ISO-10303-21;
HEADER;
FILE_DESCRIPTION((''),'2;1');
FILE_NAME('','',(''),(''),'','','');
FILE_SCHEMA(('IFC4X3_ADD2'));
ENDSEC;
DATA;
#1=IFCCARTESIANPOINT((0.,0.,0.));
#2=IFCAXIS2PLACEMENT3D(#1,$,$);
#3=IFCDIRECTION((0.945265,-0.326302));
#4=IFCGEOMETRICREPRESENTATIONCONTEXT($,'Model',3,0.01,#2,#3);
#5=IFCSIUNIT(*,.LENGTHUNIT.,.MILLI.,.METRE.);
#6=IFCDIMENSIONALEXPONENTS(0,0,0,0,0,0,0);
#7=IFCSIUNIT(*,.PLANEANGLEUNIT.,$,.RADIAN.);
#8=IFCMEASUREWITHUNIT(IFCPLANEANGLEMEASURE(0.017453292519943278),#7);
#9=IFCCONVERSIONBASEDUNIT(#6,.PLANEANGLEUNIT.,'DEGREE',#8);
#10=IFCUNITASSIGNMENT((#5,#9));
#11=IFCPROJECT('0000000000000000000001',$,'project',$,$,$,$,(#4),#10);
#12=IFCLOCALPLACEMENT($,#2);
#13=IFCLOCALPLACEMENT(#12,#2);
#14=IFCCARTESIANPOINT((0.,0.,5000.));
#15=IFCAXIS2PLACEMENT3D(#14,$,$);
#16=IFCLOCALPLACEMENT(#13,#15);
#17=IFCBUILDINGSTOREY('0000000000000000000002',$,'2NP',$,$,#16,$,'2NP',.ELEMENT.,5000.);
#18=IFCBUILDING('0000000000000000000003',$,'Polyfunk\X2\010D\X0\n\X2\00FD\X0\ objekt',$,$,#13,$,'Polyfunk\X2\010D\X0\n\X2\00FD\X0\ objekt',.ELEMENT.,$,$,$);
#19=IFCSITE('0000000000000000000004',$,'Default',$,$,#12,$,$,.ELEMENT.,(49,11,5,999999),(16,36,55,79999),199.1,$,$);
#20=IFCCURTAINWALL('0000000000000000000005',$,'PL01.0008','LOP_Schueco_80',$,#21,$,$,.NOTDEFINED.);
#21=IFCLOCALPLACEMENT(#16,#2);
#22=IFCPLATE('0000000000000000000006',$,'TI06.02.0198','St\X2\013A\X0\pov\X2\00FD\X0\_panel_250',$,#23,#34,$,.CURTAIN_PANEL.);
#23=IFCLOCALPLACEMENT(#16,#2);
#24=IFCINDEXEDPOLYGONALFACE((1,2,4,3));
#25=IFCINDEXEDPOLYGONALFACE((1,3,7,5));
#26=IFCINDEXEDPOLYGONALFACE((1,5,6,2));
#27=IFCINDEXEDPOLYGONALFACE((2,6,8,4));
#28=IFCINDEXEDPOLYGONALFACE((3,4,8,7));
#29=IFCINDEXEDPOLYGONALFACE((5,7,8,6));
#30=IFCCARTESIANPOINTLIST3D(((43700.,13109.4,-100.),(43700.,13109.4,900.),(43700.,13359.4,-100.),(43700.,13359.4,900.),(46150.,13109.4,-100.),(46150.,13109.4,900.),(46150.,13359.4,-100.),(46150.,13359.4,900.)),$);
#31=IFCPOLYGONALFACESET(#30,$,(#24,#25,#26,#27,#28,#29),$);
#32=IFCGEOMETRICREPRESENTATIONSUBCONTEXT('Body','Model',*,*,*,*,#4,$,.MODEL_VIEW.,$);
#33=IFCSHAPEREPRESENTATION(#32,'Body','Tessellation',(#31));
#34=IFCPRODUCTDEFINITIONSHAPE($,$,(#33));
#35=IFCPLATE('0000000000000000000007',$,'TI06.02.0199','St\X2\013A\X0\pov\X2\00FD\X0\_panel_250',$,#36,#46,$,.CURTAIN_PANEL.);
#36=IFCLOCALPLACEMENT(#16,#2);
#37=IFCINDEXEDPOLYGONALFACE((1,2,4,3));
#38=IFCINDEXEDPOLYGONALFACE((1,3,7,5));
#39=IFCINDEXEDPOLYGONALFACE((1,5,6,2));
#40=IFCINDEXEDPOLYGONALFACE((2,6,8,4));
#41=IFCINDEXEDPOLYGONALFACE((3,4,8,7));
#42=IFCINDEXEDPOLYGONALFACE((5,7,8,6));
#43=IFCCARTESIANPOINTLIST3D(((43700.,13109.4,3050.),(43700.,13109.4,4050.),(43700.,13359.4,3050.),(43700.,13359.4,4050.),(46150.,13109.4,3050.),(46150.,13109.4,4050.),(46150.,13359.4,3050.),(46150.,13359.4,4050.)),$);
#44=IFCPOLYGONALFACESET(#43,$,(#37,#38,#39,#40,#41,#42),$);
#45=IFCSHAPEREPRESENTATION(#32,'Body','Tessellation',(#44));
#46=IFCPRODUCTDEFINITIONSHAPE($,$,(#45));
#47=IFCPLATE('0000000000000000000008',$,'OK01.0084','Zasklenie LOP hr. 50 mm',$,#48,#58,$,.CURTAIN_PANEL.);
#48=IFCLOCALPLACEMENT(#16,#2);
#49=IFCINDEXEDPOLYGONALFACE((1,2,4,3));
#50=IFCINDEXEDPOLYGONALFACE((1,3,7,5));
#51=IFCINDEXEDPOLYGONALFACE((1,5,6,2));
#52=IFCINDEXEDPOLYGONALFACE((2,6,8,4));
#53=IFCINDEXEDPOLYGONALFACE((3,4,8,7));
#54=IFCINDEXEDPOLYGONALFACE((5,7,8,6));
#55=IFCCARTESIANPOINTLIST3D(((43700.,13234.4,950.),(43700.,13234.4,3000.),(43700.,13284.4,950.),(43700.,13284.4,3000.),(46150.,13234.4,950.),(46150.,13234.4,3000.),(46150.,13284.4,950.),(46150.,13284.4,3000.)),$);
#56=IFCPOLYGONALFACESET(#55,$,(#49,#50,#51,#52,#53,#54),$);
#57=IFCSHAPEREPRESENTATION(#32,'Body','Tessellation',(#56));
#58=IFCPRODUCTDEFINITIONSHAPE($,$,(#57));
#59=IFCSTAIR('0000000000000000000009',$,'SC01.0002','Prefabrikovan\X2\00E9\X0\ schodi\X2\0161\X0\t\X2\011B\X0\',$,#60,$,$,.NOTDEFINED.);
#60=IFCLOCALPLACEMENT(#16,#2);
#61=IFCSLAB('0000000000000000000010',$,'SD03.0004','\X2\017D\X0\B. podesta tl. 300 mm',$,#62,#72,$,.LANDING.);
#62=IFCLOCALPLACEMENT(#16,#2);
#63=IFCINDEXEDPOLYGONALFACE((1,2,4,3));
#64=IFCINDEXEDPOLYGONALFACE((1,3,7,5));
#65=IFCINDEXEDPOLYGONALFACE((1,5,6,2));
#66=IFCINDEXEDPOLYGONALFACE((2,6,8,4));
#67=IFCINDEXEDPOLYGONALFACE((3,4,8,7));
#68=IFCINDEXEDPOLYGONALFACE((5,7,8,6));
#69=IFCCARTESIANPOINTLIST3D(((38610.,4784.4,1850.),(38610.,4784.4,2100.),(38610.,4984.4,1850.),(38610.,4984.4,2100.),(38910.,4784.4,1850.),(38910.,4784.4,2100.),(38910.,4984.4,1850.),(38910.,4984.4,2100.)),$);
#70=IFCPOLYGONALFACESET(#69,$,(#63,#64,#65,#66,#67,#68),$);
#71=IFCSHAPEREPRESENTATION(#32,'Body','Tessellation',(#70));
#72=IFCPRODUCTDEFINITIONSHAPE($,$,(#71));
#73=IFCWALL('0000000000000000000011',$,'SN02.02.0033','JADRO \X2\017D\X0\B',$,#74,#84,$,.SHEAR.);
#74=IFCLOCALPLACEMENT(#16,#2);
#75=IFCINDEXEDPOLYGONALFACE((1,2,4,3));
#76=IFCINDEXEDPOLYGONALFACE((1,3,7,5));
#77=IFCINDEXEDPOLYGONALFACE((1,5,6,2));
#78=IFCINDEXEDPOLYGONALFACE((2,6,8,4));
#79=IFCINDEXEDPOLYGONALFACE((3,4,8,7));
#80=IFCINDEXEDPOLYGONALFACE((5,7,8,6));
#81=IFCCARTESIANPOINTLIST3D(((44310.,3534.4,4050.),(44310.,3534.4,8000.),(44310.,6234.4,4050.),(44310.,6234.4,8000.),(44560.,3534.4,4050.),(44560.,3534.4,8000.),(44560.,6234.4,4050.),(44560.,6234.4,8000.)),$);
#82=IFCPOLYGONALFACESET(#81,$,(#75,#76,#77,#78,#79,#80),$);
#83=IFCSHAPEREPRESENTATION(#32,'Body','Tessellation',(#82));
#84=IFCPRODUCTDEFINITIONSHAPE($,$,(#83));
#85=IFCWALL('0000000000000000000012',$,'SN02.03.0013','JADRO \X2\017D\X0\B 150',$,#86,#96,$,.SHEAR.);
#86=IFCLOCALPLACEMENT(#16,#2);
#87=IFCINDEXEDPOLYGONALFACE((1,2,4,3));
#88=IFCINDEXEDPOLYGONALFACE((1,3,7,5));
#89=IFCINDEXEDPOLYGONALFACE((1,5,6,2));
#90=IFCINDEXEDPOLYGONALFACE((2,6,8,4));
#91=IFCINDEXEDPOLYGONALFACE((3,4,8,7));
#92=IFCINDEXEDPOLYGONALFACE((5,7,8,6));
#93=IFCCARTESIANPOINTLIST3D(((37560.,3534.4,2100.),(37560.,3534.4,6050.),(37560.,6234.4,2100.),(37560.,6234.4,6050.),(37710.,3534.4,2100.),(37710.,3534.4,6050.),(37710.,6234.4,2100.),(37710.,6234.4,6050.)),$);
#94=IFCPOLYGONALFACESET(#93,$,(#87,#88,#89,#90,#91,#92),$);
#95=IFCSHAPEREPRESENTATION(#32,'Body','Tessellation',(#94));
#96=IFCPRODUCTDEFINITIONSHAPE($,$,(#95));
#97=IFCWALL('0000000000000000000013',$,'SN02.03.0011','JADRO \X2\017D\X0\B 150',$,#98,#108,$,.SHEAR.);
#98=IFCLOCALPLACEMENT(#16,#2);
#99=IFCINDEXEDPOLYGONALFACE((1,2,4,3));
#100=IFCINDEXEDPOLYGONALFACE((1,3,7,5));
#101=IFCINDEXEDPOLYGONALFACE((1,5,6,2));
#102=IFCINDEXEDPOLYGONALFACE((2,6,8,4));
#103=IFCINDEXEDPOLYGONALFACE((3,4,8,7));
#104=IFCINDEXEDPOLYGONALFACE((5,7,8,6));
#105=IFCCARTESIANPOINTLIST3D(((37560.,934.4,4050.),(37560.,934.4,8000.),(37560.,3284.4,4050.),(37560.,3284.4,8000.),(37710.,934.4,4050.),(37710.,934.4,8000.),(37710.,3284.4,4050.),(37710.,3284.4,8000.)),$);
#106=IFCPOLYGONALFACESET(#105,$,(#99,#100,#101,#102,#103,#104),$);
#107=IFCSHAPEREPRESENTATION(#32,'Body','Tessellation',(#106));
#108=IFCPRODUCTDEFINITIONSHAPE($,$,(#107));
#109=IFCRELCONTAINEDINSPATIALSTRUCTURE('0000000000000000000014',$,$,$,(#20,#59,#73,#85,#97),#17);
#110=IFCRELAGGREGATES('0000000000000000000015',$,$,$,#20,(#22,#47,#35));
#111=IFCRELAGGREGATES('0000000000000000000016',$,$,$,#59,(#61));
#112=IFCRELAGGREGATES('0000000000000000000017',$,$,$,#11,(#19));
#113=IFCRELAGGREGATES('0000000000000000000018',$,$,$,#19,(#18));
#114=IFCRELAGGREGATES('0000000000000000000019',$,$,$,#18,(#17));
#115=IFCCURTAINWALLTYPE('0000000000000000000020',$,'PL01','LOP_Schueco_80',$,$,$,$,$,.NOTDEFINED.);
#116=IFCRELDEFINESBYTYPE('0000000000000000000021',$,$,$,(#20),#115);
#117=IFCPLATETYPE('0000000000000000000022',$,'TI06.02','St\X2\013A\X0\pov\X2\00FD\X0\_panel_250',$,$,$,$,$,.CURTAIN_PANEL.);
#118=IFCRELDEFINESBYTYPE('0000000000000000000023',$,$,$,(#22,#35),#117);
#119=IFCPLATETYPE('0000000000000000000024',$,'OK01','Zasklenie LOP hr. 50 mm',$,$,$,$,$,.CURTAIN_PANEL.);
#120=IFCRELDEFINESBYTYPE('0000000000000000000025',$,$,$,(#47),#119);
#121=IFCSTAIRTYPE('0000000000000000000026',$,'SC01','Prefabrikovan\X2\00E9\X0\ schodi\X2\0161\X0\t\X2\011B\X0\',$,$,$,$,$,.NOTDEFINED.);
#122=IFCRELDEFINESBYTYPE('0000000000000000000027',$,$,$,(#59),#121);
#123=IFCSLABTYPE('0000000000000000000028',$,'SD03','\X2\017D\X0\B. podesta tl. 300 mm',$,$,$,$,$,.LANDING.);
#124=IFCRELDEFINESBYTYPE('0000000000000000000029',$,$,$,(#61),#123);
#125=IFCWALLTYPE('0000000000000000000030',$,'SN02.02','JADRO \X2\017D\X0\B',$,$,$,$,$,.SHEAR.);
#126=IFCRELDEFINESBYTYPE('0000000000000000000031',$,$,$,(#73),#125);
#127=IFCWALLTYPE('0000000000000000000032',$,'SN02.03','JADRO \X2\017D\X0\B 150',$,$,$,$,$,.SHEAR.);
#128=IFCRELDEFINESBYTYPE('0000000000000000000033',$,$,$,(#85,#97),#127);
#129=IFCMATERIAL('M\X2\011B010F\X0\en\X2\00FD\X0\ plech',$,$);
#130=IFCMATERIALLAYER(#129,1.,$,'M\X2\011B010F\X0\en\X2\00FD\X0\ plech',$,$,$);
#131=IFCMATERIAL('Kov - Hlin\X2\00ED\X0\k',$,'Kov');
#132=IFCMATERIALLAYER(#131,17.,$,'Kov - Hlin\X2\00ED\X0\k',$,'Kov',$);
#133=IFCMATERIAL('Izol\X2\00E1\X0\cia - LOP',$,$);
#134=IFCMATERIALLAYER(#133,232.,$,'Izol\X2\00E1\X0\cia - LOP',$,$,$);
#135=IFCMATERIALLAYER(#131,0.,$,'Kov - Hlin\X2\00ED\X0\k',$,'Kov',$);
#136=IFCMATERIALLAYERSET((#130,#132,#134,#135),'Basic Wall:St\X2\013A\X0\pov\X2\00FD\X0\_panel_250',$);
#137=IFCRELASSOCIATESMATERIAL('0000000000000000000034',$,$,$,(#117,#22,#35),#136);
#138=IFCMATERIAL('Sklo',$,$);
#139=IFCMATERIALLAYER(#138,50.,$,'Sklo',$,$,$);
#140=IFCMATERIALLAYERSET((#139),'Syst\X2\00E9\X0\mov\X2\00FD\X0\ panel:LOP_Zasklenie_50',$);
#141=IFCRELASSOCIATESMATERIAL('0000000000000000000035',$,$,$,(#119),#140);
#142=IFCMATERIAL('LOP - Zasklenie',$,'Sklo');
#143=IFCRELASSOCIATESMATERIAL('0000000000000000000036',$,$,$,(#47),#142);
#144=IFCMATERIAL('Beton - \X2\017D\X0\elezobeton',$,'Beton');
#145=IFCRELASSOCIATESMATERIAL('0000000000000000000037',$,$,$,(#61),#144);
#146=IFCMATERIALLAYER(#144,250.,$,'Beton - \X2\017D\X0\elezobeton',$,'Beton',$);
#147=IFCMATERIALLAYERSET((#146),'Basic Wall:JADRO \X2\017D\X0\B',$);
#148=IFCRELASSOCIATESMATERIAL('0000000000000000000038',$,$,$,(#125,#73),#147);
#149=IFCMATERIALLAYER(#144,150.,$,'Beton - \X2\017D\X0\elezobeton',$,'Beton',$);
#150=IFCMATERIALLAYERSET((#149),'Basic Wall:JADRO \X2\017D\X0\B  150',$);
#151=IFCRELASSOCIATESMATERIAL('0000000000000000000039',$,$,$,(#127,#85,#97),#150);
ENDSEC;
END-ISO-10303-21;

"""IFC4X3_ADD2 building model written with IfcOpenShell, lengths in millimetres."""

from ifc_helpers import new_model, entity, si_unit, converted_unit, direction, frame, frame_2d, origin, origin_2d_with_axis, place, context, subcontext, project, spatial, polyline, rectangle, extrude, clip, bounded_halfspace, source, transform, mapped, material, layer, layer_set, layer_usage, type_object, type_shapes, element, aggregate, save


model = new_model("IFC4X3_ADD2")

# Units and contexts
model_context = context("Model", 3, precision=0.01, world=origin(), true_north=direction((0.945265, -0.326302)))
body_context = subcontext(model_context, "Body", "Model", "MODEL_VIEW")
ifc_project = project(units=[si_unit("LENGTHUNIT", "METRE", prefix="MILLI"), converted_unit("PLANEANGLEUNIT", "DEGREE", entity("IfcPlaneAngleMeasure", 0.017453292519943278), si_unit("PLANEANGLEUNIT", "RADIAN"), dimensions=[0, 0, 0, 0, 0, 0, 0])], contexts=[model_context])

# Site, building, storey
site_placement = place(None, origin())
site = spatial("IfcSite", under=ifc_project, at=site_placement, Name="Default", CompositionType="ELEMENT", RefLatitude=(49, 11, 5, 999999), RefLongitude=(16, 36, 55, 79999), RefElevation=199.1)
building_placement = place(site_placement, origin())
building = spatial("IfcBuilding", under=site, at=building_placement, Name="Polyfunkčný objekt", LongName="Polyfunkčný objekt", CompositionType="ELEMENT")
storey_placement = place(building_placement, frame((0.0, 0.0, 5000.0)))
storey = spatial("IfcBuildingStorey", under=building, at=storey_placement, Name="2NP", LongName="2NP", CompositionType="ELEMENT", Elevation=5000.0)

# Curtain wall, plates
curtain_wall_type = type_object("IfcCurtainWallType", Name="PL01", Description="LOP_Schueco_80", PredefinedType="NOTDEFINED")
curtain_wall_placement = place(storey_placement, frame((0.0, 0.0, -5000.0)))
curtain_wall = element("IfcCurtainWall", 1, at=curtain_wall_placement, inside=storey, type_object=curtain_wall_type, Name="PL01.0008", Description="LOP_Schueco_80", PredefinedType="NOTDEFINED")
ifc_material_1 = material(Name="Měďený plech")
ifc_layer_1 = layer(ifc_material_1, 1.0, Name="Měďený plech")
ifc_material_2 = material(Name="Kov - Hliník", Category="Kov")
ifc_layer_2 = layer(ifc_material_2, 17.0, Name="Kov - Hliník", Category="Kov")
ifc_material_3 = material(Name="Izolácia - LOP")
ifc_layer_3 = layer(ifc_material_3, 232.0, Name="Izolácia - LOP")
ifc_layer_4 = layer(ifc_material_2, 0.0, Name="Kov - Hliník", Category="Kov")
ifc_layer_set_1 = layer_set([ifc_layer_1, ifc_layer_2, ifc_layer_3, ifc_layer_4], Name="Basic Wall:Stĺpový_panel_250")
ifc_layer_usage_1 = layer_usage(ifc_layer_set_1, "AXIS2", "NEGATIVE", 125.0)
plate_type_1 = type_object("IfcPlateType", Name="TI06.02", Description="Stĺpový_panel_250", PredefinedType="CURTAIN_PANEL", material=ifc_layer_set_1)
plate_1_placement = place(storey_placement, frame((43700.0, 13234.4, -100.0)))
plate_1 = element("IfcPlate", 2, at=plate_1_placement, type_object=plate_type_1, material=ifc_layer_usage_1, Name="TI06.02.0198", Description="Stĺpový_panel_250", PredefinedType="CURTAIN_PANEL", context=body_context, shape_type="SweptSolid", body=[
    extrude(rectangle(XDim=250.0, YDim=2450.0, at=frame_2d((0.0, 0.0), x_axis=(1.0, 0.0))), frame((1225.0, 0.0, 0.0), z_axis=(0.0, 0.0, 1.0), x_axis=(0.0, 1.0, 0.0)), (0.0, 0.0, 1.0), 1000.0),
])
ifc_layer_usage_2 = layer_usage(ifc_layer_set_1, "AXIS2", "NEGATIVE", 125.0)
plate_2_placement = place(storey_placement, frame((43700.0, 13234.4, 3050.0)))
plate_2 = element("IfcPlate", 3, at=plate_2_placement, type_object=plate_type_1, material=ifc_layer_usage_2, Name="TI06.02.0199", Description="Stĺpový_panel_250", PredefinedType="CURTAIN_PANEL", context=body_context, shape_type="SweptSolid", body=[
    extrude(rectangle(XDim=250.0, YDim=2450.0, at=frame_2d((0.0, 0.0), x_axis=(1.0, 0.0))), frame((1225.0, 0.0, 0.0), z_axis=(0.0, 0.0, 1.0), x_axis=(0.0, 1.0, 0.0)), (0.0, 0.0, 1.0), 1000.0),
])
ifc_material_4 = material(Name="LOP - Zasklenie", Category="Sklo")
ifc_material_5 = material(Name="Sklo")
ifc_layer_5 = layer(ifc_material_5, 50.0, Name="Sklo")
ifc_layer_set_2 = layer_set([ifc_layer_5], Name="Systémový panel:LOP_Zasklenie_50")
plate_type_2 = type_object("IfcPlateType", Name="OK01", Description="Zasklenie LOP hr. 50 mm", PredefinedType="CURTAIN_PANEL", material=ifc_layer_set_2)
shared_shape_1 = source(origin(), body_context, "Body", "SweptSolid", [
    extrude(rectangle(XDim=50.0, YDim=2450.0, at=origin_2d_with_axis()), frame((0.0, 25.0, 0.0), z_axis=(0.0, 0.0, 1.0), x_axis=(0.0, 1.0, 0.0)), (0.0, 0.0, 1.0), 2050.0),
])
type_shapes(plate_type_2, [shared_shape_1])
plate_3_placement = place(curtain_wall_placement, frame((44925.0, 13234.4, 5950.0)))
plate_3 = element("IfcPlate", 4, at=plate_3_placement, type_object=plate_type_2, material=ifc_material_4, Name="OK01.0084", Description="Zasklenie LOP hr. 50 mm", PredefinedType="CURTAIN_PANEL", context=body_context, shape_type="MappedRepresentation", body=[
    mapped(shared_shape_1, transform((0.0, 0.0, 0.0), scale=1.0)),
])
aggregate(curtain_wall, [plate_1, plate_3, plate_2])

# Stair, slab
stair_type = type_object("IfcStairType", Name="SC01", Description="Prefabrikované schodiště", PredefinedType="NOTDEFINED")
stair_placement = place(storey_placement, origin())
stair = element("IfcStair", 5, at=stair_placement, inside=storey, type_object=stair_type, Name="SC01.0002", Description="Prefabrikované schodiště", PredefinedType="NOTDEFINED")
ifc_material_6 = material(Name="Beton - Železobeton", Category="Beton")
slab_type = type_object("IfcSlabType", Name="SD03", Description="ŽB. podesta tl. 300 mm", PredefinedType="LANDING")
slab_placement = place(stair_placement, frame((38610.0, 4784.4, 0.0)))
slab = element("IfcSlab", 6, at=slab_placement, type_object=slab_type, material=ifc_material_6, Name="SD03.0004", Description="ŽB. podesta tl. 300 mm", PredefinedType="LANDING", context=body_context, shape_type="SweptSolid", body=[
    extrude(rectangle(XDim=200.0, YDim=300.0, at=frame_2d((0.0, 0.0), x_axis=(1.0, 0.0))), frame((150.0, 100.0, 1850.0), z_axis=(0.0, 0.0, 1.0), x_axis=(0.0, 1.0, 0.0)), (0.0, 0.0, 1.0), 250.0),
])
aggregate(stair, [slab])

# Walls
ifc_layer_6 = layer(ifc_material_6, 250.0, Name="Beton - Železobeton", Category="Beton")
ifc_layer_set_3 = layer_set([ifc_layer_6], Name="Basic Wall:JADRO ŽB")
wall_type_1 = type_object("IfcWallType", Name="SN02.02", Description="JADRO ŽB", PredefinedType="SHEAR", material=ifc_layer_set_3)
wall_1_placement = place(storey_placement, frame((44435.0, 6234.4, 4050.0), z_axis=(0.0, 0.0, 1.0), x_axis=(0.0, -1.0, 0.0)))
element("IfcWall", 7, at=wall_1_placement, inside=storey, type_object=wall_type_1, material=ifc_layer_set_3, Name="SN02.02.0033", Description="JADRO ŽB", PredefinedType="SHEAR", context=body_context, shape_type="Clipping", body=[
    clip(clip(extrude(rectangle(XDim=2700.0, YDim=250.0, at=frame_2d((1350.0, 0.0), x_axis=(-1.0, 0.0))), origin(), (0.0, 0.0, 1.0), 3950.0), bounded_halfspace(frame((2700.0, -125.0, 0.0), z_axis=(0.0, 0.0, 1.0), x_axis=(0.0, -1.0, 0.0)), True, frame((2700.0, -125.0, 0.0)), polyline([(0.0, 0.0), (0.0, 250.0), (-2700.0, 250.0), (-2700.0, 0.0), (0.0, 0.0)]))), bounded_halfspace(frame((0.0, -125.0, 3950.0), z_axis=(0.0, 0.0, -1.0), x_axis=(0.0, 1.0, 0.0)), True, frame((0.0, -125.0, 3950.0)), polyline([(0.0, 0.0), (2700.0, 0.0), (2700.0, 250.0), (0.0, 250.0), (0.0, 0.0)]))),
])
ifc_layer_7 = layer(ifc_material_6, 150.0, Name="Beton - Železobeton", Category="Beton")
ifc_layer_set_4 = layer_set([ifc_layer_7], Name="Basic Wall:JADRO ŽB  150")
wall_type_2 = type_object("IfcWallType", Name="SN02.03", Description="JADRO ŽB 150", PredefinedType="SHEAR", material=ifc_layer_set_4)
wall_2_placement = place(storey_placement, frame((37635.0, 6234.4, 2100.0), z_axis=(0.0, 0.0, 1.0), x_axis=(0.0, -1.0, 0.0)))
element("IfcWall", 8, at=wall_2_placement, inside=storey, type_object=wall_type_2, material=ifc_layer_set_4, Name="SN02.03.0013", Description="JADRO ŽB 150", PredefinedType="SHEAR", context=body_context, shape_type="SweptSolid", body=[
    extrude(rectangle(XDim=2700.0, YDim=150.0, at=frame_2d((1350.0, 0.0), x_axis=(-1.0, 0.0))), origin(), (0.0, 0.0, 1.0), 3950.0),
])
wall_3_placement = place(storey_placement, frame((37635.0, 3284.4, 4050.0), z_axis=(0.0, 0.0, 1.0), x_axis=(0.0, -1.0, 0.0)))
element("IfcWall", 9, at=wall_3_placement, inside=storey, type_object=wall_type_2, material=ifc_layer_set_4, Name="SN02.03.0011", Description="JADRO ŽB 150", PredefinedType="SHEAR", context=body_context, shape_type="SweptSolid", body=[
    extrude(rectangle(XDim=2350.0, YDim=150.0, at=frame_2d((1175.0, 0.0), x_axis=(-1.0, 0.0))), origin(), (0.0, 0.0, 1.0), 3950.0),
])

save(model, "model.ifc")
